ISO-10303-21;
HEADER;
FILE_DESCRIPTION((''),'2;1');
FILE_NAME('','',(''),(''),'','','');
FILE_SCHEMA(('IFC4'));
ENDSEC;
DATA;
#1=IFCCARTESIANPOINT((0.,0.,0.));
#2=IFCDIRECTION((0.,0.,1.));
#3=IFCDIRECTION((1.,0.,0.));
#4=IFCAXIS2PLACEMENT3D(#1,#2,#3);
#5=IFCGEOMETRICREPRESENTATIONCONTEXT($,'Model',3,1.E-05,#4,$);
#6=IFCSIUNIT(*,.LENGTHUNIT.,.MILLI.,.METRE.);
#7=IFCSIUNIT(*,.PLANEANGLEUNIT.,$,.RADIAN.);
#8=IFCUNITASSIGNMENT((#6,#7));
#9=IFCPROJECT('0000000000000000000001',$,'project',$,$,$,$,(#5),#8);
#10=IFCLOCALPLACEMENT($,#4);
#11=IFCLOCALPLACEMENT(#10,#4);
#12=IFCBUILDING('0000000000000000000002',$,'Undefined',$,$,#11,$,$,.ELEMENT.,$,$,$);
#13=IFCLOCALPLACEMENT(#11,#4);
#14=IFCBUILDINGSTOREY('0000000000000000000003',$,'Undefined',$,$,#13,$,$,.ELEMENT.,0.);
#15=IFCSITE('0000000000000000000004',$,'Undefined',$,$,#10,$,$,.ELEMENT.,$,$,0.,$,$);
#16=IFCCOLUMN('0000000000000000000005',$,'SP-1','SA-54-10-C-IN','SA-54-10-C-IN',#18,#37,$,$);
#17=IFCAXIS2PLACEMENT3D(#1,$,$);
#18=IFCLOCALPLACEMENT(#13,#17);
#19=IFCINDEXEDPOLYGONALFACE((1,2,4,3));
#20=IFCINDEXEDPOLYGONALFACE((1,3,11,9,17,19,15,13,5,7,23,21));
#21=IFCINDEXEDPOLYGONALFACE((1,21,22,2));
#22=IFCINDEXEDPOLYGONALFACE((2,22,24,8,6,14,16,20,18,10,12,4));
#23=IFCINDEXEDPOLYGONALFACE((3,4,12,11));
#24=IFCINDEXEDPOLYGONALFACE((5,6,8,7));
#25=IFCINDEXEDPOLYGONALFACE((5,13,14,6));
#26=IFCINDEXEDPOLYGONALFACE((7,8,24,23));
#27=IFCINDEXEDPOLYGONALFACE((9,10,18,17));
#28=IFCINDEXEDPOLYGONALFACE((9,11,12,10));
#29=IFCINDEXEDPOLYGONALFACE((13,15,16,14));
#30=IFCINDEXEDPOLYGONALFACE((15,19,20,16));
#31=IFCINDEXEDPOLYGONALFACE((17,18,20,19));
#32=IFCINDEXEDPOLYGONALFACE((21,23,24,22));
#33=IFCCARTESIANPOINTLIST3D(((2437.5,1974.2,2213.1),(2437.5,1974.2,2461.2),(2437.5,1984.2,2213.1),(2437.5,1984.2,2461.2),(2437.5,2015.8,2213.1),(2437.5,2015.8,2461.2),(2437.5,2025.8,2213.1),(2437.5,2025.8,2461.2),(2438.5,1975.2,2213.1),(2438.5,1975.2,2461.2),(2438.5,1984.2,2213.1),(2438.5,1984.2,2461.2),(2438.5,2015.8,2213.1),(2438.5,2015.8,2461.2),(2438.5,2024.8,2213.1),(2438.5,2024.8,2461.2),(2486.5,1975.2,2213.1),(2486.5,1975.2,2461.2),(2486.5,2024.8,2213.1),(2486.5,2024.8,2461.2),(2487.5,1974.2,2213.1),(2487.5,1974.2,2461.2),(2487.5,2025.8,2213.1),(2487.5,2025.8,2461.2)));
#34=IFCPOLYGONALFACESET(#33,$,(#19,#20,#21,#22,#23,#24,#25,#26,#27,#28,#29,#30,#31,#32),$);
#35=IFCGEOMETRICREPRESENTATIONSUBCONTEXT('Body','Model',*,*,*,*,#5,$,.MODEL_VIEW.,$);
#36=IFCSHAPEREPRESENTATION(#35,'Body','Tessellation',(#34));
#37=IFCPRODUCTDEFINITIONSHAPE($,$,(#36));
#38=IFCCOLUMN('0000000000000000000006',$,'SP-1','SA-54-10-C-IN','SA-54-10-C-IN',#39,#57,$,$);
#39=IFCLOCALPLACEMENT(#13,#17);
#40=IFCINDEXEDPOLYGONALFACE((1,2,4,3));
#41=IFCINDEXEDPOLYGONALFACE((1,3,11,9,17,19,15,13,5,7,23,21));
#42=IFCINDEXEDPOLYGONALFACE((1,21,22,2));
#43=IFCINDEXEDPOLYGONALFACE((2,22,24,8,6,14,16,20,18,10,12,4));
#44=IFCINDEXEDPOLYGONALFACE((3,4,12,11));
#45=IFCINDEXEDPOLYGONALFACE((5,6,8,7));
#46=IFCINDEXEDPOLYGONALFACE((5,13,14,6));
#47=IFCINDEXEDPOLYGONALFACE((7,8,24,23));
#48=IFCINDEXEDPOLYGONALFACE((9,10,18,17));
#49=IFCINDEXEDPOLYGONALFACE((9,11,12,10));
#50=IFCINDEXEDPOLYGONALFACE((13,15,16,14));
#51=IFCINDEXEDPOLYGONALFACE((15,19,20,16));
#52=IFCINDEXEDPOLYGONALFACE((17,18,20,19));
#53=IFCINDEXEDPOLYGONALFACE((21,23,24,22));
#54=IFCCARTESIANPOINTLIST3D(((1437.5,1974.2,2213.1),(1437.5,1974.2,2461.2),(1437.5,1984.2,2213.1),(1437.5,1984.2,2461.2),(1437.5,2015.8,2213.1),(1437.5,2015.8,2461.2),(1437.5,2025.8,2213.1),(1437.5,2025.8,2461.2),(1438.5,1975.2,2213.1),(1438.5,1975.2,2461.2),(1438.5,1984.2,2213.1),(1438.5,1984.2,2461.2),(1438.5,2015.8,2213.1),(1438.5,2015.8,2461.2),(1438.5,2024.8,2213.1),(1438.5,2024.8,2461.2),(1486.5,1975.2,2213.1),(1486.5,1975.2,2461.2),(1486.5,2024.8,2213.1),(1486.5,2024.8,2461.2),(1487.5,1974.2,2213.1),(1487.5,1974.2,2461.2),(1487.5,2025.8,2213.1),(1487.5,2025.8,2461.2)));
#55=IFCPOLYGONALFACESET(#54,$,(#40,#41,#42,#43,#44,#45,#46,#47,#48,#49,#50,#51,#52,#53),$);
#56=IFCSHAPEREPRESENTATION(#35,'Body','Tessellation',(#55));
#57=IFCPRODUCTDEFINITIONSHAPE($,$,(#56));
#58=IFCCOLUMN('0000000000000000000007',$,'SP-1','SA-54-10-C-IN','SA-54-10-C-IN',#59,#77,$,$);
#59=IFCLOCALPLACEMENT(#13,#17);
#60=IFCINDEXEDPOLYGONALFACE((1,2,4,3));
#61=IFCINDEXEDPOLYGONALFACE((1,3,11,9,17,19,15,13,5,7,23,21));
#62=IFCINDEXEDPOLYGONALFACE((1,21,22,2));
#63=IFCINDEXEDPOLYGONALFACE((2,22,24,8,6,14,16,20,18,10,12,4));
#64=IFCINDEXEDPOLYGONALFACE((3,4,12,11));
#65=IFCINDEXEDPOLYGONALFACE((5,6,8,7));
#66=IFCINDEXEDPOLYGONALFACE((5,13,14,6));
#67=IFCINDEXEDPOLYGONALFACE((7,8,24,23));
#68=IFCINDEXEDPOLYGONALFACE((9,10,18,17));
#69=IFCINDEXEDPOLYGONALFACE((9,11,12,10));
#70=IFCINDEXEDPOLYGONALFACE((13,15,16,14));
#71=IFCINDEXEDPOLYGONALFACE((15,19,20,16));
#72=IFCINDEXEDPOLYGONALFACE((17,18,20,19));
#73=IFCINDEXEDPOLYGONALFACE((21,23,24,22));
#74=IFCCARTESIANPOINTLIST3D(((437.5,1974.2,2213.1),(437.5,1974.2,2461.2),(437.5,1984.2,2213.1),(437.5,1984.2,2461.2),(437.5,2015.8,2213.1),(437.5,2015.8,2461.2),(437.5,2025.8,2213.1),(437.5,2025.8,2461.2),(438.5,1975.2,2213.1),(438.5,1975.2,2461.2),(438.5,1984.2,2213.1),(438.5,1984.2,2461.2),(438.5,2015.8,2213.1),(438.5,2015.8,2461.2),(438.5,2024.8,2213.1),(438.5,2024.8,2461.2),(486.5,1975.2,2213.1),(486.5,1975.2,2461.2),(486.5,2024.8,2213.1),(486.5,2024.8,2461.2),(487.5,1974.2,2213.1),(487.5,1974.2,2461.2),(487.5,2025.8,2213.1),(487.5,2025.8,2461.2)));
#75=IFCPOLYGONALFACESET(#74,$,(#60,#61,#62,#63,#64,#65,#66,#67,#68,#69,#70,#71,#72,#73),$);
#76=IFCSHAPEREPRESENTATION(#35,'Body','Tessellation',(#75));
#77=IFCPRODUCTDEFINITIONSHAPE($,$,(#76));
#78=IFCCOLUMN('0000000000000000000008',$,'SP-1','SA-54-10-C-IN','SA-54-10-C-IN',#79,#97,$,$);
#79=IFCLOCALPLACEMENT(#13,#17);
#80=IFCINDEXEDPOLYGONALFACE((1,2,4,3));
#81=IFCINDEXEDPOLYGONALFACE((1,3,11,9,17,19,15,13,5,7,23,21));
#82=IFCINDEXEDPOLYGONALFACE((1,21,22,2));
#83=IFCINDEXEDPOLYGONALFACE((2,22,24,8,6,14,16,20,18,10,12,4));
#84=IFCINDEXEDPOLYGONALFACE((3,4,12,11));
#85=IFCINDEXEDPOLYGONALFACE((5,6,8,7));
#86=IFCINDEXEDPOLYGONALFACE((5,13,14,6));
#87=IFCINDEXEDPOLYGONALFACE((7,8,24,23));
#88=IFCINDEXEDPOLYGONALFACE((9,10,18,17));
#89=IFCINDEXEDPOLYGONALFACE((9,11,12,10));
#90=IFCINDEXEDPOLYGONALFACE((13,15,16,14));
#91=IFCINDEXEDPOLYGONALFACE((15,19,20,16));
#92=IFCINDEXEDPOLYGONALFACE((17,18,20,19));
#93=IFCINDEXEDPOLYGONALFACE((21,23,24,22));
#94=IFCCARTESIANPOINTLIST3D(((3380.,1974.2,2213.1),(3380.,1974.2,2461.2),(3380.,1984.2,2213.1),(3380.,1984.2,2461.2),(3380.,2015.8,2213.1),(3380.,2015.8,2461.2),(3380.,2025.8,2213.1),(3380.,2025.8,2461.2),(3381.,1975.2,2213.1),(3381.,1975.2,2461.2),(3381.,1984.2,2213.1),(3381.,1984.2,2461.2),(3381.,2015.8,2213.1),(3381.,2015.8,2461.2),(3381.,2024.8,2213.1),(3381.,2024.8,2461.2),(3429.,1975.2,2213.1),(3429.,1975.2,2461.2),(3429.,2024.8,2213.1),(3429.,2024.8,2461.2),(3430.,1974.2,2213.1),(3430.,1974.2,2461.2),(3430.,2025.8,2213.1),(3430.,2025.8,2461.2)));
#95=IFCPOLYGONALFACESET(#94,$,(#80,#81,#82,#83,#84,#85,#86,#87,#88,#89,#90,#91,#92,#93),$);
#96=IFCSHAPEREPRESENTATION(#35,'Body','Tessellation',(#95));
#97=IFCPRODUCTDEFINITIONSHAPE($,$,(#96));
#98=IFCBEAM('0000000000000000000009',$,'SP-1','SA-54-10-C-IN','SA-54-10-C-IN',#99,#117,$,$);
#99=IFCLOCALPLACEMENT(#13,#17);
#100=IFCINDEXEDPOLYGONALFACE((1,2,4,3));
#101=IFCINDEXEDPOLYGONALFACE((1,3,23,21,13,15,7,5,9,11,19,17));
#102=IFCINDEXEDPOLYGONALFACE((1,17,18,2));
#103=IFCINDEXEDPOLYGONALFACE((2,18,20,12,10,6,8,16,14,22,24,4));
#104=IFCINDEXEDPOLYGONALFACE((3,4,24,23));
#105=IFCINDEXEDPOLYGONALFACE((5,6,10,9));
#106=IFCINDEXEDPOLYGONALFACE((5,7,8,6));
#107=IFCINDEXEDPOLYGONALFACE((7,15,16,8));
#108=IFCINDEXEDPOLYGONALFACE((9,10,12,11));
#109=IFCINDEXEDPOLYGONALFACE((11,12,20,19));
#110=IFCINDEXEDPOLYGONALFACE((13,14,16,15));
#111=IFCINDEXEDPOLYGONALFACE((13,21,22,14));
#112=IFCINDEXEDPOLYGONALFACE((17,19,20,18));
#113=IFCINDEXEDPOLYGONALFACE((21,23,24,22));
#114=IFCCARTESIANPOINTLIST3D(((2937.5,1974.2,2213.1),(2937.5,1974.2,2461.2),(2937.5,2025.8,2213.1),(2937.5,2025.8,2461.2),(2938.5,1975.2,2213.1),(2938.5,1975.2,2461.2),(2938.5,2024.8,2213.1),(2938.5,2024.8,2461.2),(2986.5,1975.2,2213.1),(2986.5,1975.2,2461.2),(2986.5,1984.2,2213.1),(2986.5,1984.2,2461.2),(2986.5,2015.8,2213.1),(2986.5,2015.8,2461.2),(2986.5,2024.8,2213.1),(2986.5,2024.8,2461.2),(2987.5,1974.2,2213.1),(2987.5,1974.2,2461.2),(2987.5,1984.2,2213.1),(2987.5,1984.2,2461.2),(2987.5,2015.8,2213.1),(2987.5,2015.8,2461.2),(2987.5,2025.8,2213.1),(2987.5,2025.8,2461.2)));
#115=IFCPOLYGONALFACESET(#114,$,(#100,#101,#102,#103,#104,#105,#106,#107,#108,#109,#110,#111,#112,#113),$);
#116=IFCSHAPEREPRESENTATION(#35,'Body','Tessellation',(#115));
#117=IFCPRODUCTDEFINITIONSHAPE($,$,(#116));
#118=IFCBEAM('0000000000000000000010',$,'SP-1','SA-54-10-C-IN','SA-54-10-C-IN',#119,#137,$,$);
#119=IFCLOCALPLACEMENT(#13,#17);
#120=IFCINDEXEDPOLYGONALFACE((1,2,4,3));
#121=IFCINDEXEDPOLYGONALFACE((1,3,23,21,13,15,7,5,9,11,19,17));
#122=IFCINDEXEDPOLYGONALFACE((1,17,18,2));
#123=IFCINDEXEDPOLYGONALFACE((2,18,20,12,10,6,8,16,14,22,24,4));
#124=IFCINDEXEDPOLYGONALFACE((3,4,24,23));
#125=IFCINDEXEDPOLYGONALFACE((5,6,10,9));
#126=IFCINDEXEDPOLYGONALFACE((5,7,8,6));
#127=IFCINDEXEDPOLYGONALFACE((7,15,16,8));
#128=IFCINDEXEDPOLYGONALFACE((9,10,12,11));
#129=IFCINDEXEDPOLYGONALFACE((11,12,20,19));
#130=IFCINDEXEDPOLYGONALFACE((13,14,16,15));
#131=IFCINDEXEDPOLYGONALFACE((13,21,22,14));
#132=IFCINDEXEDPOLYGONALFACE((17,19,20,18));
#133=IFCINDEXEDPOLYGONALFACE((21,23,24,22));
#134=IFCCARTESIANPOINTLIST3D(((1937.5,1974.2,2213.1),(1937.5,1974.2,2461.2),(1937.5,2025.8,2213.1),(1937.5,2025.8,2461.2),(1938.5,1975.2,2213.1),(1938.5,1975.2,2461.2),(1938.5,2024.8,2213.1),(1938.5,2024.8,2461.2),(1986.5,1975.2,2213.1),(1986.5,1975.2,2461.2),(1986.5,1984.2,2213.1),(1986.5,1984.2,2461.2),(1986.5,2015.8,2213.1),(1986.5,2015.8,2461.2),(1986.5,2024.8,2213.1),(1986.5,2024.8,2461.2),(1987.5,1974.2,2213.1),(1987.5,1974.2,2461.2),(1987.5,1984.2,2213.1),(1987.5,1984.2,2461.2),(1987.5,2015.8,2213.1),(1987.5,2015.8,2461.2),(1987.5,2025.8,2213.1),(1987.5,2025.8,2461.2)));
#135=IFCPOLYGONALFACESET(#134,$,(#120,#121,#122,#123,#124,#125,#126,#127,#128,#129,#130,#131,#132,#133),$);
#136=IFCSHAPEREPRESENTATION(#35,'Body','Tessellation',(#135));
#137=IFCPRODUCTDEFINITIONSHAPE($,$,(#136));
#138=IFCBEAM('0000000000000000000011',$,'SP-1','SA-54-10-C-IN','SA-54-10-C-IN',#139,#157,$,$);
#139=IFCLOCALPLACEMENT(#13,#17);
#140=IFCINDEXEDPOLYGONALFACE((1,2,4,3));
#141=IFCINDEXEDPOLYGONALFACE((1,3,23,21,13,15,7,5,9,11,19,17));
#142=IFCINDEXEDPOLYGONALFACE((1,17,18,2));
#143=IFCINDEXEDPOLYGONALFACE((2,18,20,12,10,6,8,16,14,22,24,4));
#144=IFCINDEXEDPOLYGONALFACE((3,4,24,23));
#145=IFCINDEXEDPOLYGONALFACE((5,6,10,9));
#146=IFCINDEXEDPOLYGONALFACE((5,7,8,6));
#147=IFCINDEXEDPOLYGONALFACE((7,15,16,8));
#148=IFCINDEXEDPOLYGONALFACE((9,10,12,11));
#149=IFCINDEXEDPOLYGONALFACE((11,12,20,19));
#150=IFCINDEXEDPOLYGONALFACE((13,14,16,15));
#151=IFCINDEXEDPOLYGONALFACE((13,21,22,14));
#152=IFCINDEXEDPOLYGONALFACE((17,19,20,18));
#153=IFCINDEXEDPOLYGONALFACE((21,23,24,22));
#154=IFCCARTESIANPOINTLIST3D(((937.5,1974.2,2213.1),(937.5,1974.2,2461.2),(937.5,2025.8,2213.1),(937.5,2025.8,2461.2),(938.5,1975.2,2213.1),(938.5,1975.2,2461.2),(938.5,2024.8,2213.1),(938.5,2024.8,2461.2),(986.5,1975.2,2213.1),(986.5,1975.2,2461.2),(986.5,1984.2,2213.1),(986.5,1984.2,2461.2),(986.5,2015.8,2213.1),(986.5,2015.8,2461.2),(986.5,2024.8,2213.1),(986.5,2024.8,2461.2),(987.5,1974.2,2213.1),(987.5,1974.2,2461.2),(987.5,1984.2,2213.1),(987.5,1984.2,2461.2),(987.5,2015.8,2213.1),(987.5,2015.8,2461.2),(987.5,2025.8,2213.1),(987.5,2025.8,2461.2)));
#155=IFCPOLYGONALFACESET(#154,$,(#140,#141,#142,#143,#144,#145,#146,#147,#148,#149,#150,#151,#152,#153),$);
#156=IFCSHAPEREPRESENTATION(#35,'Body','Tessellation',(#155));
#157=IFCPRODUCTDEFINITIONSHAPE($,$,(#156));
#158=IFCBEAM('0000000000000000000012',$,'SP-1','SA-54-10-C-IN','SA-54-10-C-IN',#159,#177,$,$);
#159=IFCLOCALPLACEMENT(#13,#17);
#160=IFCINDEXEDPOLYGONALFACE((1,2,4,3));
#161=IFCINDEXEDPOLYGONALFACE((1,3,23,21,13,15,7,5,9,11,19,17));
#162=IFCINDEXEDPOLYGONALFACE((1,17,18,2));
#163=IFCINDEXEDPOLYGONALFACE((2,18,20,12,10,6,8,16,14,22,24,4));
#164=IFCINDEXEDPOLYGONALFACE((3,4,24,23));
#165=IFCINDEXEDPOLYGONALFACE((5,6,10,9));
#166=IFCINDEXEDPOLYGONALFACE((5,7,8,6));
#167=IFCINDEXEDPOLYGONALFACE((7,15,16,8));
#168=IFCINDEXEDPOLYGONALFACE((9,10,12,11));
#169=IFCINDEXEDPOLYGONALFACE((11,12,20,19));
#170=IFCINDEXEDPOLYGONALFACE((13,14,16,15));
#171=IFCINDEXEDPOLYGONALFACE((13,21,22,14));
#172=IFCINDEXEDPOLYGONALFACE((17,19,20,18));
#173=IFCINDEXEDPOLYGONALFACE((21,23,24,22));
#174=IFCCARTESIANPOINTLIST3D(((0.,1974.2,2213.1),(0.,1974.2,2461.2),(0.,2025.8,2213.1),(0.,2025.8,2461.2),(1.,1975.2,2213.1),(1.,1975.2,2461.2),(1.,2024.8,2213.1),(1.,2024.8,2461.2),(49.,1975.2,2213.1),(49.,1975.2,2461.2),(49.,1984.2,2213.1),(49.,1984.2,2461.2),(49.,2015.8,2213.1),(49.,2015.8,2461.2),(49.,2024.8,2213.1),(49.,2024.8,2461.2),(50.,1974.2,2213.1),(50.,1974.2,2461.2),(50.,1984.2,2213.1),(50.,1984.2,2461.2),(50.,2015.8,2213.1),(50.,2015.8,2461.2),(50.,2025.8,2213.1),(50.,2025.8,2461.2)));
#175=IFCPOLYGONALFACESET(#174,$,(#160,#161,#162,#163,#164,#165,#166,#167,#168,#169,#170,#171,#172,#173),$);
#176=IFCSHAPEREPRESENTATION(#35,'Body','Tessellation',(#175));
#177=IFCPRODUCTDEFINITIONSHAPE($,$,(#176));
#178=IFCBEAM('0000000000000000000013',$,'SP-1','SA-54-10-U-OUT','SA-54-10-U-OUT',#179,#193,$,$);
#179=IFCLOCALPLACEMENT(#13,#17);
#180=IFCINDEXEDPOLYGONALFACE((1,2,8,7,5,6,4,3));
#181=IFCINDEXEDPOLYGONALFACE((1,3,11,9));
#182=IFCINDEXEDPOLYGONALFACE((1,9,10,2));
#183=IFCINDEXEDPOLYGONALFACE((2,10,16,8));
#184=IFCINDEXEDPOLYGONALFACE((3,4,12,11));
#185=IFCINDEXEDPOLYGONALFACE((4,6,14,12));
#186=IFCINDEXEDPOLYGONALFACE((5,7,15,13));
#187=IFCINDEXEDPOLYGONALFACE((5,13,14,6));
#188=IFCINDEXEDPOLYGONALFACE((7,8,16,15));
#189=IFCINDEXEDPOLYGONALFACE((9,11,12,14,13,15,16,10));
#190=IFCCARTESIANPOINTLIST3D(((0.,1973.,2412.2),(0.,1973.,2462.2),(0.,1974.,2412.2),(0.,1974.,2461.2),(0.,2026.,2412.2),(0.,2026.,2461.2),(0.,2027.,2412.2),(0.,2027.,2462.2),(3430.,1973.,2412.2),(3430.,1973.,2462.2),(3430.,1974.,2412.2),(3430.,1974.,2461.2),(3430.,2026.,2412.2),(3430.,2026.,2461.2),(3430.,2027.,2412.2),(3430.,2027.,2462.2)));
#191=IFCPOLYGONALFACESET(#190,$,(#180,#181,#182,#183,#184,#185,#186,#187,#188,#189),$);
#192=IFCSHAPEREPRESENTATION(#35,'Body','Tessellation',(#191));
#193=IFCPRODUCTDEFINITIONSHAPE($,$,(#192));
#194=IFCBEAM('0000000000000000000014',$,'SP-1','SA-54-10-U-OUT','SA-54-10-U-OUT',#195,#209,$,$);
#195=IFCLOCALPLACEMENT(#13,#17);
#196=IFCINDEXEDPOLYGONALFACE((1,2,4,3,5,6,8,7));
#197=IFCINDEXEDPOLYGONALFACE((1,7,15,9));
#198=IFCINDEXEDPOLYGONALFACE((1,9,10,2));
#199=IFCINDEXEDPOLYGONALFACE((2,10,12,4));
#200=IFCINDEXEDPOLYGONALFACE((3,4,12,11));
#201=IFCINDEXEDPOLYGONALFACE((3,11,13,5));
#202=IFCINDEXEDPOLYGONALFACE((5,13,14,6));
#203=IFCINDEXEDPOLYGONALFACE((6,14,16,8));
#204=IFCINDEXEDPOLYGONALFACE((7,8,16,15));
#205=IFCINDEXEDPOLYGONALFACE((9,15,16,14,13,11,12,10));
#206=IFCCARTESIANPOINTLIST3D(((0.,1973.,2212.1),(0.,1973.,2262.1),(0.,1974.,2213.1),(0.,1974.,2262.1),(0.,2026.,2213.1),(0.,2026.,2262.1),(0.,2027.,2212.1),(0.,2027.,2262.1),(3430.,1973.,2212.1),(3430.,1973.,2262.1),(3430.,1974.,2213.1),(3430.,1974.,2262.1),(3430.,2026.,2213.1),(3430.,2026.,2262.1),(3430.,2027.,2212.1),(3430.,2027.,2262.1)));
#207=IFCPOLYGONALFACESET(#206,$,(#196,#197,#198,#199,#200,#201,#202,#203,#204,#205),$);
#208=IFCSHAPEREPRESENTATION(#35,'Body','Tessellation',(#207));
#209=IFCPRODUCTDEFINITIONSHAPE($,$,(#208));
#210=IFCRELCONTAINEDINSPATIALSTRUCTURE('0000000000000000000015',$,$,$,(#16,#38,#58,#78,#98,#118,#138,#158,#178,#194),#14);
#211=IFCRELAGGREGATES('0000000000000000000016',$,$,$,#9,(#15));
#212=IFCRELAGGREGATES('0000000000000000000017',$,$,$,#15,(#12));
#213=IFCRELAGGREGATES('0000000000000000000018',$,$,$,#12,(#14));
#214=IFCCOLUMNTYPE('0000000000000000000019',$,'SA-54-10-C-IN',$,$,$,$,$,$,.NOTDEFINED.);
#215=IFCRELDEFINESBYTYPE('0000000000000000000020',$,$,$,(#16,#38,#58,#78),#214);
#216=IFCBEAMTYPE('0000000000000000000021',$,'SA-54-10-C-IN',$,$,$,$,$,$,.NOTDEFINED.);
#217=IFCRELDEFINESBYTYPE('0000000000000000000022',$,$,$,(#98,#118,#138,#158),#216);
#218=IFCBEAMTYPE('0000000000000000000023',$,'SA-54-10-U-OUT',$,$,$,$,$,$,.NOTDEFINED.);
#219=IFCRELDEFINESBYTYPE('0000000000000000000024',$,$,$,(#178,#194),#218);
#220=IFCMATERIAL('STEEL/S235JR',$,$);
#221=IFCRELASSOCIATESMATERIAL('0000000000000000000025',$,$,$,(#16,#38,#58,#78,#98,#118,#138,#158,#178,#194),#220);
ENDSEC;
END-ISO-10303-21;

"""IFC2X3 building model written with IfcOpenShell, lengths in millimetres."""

from ifc_helpers import new_model, si_unit, frame, origin_with_axes, origin_2d_with_axis, place, context, subcontext, project, spatial, u_section, c_section, extrude, material, type_object, element, save


model = new_model("IFC2X3")

# Units and contexts
model_context = context("Model", 3, precision=1e-05, world=origin_with_axes())
body_context = subcontext(model_context, "Body", "Model", "MODEL_VIEW")
ifc_project = project(units=[si_unit("LENGTHUNIT", "METRE", prefix="MILLI"), si_unit("PLANEANGLEUNIT", "RADIAN")], contexts=[model_context])

# Site, building, storey
site_placement = place(None, origin_with_axes())
site = spatial("IfcSite", under=ifc_project, at=site_placement, Name="Undefined", CompositionType="ELEMENT", RefElevation=0.0)
building_placement = place(site_placement, origin_with_axes())
building = spatial("IfcBuilding", under=site, at=building_placement, Name="Undefined", CompositionType="ELEMENT")
storey_placement = place(building_placement, origin_with_axes())
storey = spatial("IfcBuildingStorey", under=building, at=storey_placement, Name="Undefined", CompositionType="ELEMENT", Elevation=0.0)

# Columns
ifc_material = material(Name="STEEL/S235JR")
column_type = type_object("IfcColumnType", Name="SA-54-10-C-IN", PredefinedType="NOTDEFINED")
for number, where, z_axis, x_axis, name in (
    (1, (2462.5, 2000.0, 2237.1), (0.0, 0.0, 1.0), (1.0, 0.0, 0.0), "SP-1"),
    (2, (1462.5, 2000.0, 2237.1), (0.0, 0.0, 1.0), (1.0, 0.0, 0.0), "SP-1"),
    (3, (462.5, 2000.0, 2237.1), (0.0, 0.0, 1.0), (1.0, 0.0, 0.0), "SP-1"),
    (4, (3405.0, 2000.0, 2237.1), (0.0, 0.0, 1.0), (1.0, 0.0, 0.0), "SP-1"),
):
    element("IfcColumn", number, at=place(storey_placement, frame(where, z_axis=z_axis, x_axis=x_axis)), inside=storey, type_object=column_type, material=ifc_material, Name=name, Description="SA-54-10-C-IN", ObjectType="SA-54-10-C-IN", context=body_context, shape_type="SweptSolid", body=[
        extrude(c_section(Depth=51.7, Width=50.0, WallThickness=1.0, Girth=10.0, at=origin_2d_with_axis()), frame((0.0, 0.0, 224.0), z_axis=(0.0, 0.0, -1.0), x_axis=(-1.0, 0.0, 0.0)), (0.0, 0.0, 1.0), 248.0),
    ])

# Beams
beam_type_1 = type_object("IfcBeamType", Name="SA-54-10-C-IN", PredefinedType="NOTDEFINED")
for number, where, z_axis, x_axis, name in (
    (5, (2962.5, 2000.0, 2437.2), (0.0, 1.0, 0.0), (0.0, 0.0, -1.0), "SP-1"),
    (6, (1962.5, 2000.0, 2437.2), (0.0, 1.0, 0.0), (0.0, 0.0, -1.0), "SP-1"),
    (7, (962.5, 2000.0, 2437.2), (0.0, 1.0, 0.0), (0.0, 0.0, -1.0), "SP-1"),
):
    element("IfcBeam", number, at=place(storey_placement, frame(where, z_axis=z_axis, x_axis=x_axis)), inside=storey, type_object=beam_type_1, material=ifc_material, Name=name, Description="SA-54-10-C-IN", ObjectType="SA-54-10-C-IN", context=body_context, shape_type="SweptSolid", body=[
        extrude(c_section(Depth=51.7, Width=50.0, WallThickness=1.0, Girth=10.0, at=origin_2d_with_axis()), frame((224.0, 0.0, 0.0), z_axis=(-1.0, 0.0, 0.0), x_axis=(0.0, -1.0, 0.0)), (0.0, 0.0, 1.0), 248.0),
    ])
beam_placement = place(storey_placement, frame((25.0, 2000.0, 2437.2), z_axis=(0.0, 1.0, 0.0), x_axis=(0.0, 0.0, -1.0)))
element("IfcBeam", 8, at=beam_placement, inside=storey, type_object=beam_type_1, material=ifc_material, Name="SP-1", Description="SA-54-10-C-IN", ObjectType="SA-54-10-C-IN", context=body_context, shape_type="SweptSolid", body=[
    extrude(c_section(Depth=51.7, Width=50.0, WallThickness=1.0, Girth=10.0, at=origin_2d_with_axis()), frame((224.0, 0.0, 0.0), z_axis=(-1.0, 0.0, 0.0), x_axis=(0.0, -1.0, 0.0)), (0.0, 0.0, 1.0), 248.0),
])
beam_type_2 = type_object("IfcBeamType", Name="SA-54-10-U-OUT", PredefinedType="NOTDEFINED")
for number, where, z_axis, x_axis, name in (
    (9, (3430.0, 2000.0, 2437.2), (0.0, 1.0, 0.0), (-1.0, 0.0, 0.0), "SP-1"),
    (10, (0.0, 2000.0, 2237.1), (0.0, 1.0, 0.0), (1.0, 0.0, 0.0), "SP-1"),
):
    element("IfcBeam", number, at=place(storey_placement, frame(where, z_axis=z_axis, x_axis=x_axis)), inside=storey, type_object=beam_type_2, material=ifc_material, Name=name, Description="SA-54-10-U-OUT", ObjectType="SA-54-10-U-OUT", context=body_context, shape_type="SweptSolid", body=[
        extrude(u_section(Depth=54.0, FlangeWidth=50.0, WebThickness=1.0, FlangeThickness=1.0, at=origin_2d_with_axis()), frame((3430.0, 0.0, 0.0), z_axis=(-1.0, 0.0, 0.0), x_axis=(0.0, -1.0, 0.0)), (0.0, 0.0, 1.0), 3430.0),
    ])

save(model, "model.ifc")
